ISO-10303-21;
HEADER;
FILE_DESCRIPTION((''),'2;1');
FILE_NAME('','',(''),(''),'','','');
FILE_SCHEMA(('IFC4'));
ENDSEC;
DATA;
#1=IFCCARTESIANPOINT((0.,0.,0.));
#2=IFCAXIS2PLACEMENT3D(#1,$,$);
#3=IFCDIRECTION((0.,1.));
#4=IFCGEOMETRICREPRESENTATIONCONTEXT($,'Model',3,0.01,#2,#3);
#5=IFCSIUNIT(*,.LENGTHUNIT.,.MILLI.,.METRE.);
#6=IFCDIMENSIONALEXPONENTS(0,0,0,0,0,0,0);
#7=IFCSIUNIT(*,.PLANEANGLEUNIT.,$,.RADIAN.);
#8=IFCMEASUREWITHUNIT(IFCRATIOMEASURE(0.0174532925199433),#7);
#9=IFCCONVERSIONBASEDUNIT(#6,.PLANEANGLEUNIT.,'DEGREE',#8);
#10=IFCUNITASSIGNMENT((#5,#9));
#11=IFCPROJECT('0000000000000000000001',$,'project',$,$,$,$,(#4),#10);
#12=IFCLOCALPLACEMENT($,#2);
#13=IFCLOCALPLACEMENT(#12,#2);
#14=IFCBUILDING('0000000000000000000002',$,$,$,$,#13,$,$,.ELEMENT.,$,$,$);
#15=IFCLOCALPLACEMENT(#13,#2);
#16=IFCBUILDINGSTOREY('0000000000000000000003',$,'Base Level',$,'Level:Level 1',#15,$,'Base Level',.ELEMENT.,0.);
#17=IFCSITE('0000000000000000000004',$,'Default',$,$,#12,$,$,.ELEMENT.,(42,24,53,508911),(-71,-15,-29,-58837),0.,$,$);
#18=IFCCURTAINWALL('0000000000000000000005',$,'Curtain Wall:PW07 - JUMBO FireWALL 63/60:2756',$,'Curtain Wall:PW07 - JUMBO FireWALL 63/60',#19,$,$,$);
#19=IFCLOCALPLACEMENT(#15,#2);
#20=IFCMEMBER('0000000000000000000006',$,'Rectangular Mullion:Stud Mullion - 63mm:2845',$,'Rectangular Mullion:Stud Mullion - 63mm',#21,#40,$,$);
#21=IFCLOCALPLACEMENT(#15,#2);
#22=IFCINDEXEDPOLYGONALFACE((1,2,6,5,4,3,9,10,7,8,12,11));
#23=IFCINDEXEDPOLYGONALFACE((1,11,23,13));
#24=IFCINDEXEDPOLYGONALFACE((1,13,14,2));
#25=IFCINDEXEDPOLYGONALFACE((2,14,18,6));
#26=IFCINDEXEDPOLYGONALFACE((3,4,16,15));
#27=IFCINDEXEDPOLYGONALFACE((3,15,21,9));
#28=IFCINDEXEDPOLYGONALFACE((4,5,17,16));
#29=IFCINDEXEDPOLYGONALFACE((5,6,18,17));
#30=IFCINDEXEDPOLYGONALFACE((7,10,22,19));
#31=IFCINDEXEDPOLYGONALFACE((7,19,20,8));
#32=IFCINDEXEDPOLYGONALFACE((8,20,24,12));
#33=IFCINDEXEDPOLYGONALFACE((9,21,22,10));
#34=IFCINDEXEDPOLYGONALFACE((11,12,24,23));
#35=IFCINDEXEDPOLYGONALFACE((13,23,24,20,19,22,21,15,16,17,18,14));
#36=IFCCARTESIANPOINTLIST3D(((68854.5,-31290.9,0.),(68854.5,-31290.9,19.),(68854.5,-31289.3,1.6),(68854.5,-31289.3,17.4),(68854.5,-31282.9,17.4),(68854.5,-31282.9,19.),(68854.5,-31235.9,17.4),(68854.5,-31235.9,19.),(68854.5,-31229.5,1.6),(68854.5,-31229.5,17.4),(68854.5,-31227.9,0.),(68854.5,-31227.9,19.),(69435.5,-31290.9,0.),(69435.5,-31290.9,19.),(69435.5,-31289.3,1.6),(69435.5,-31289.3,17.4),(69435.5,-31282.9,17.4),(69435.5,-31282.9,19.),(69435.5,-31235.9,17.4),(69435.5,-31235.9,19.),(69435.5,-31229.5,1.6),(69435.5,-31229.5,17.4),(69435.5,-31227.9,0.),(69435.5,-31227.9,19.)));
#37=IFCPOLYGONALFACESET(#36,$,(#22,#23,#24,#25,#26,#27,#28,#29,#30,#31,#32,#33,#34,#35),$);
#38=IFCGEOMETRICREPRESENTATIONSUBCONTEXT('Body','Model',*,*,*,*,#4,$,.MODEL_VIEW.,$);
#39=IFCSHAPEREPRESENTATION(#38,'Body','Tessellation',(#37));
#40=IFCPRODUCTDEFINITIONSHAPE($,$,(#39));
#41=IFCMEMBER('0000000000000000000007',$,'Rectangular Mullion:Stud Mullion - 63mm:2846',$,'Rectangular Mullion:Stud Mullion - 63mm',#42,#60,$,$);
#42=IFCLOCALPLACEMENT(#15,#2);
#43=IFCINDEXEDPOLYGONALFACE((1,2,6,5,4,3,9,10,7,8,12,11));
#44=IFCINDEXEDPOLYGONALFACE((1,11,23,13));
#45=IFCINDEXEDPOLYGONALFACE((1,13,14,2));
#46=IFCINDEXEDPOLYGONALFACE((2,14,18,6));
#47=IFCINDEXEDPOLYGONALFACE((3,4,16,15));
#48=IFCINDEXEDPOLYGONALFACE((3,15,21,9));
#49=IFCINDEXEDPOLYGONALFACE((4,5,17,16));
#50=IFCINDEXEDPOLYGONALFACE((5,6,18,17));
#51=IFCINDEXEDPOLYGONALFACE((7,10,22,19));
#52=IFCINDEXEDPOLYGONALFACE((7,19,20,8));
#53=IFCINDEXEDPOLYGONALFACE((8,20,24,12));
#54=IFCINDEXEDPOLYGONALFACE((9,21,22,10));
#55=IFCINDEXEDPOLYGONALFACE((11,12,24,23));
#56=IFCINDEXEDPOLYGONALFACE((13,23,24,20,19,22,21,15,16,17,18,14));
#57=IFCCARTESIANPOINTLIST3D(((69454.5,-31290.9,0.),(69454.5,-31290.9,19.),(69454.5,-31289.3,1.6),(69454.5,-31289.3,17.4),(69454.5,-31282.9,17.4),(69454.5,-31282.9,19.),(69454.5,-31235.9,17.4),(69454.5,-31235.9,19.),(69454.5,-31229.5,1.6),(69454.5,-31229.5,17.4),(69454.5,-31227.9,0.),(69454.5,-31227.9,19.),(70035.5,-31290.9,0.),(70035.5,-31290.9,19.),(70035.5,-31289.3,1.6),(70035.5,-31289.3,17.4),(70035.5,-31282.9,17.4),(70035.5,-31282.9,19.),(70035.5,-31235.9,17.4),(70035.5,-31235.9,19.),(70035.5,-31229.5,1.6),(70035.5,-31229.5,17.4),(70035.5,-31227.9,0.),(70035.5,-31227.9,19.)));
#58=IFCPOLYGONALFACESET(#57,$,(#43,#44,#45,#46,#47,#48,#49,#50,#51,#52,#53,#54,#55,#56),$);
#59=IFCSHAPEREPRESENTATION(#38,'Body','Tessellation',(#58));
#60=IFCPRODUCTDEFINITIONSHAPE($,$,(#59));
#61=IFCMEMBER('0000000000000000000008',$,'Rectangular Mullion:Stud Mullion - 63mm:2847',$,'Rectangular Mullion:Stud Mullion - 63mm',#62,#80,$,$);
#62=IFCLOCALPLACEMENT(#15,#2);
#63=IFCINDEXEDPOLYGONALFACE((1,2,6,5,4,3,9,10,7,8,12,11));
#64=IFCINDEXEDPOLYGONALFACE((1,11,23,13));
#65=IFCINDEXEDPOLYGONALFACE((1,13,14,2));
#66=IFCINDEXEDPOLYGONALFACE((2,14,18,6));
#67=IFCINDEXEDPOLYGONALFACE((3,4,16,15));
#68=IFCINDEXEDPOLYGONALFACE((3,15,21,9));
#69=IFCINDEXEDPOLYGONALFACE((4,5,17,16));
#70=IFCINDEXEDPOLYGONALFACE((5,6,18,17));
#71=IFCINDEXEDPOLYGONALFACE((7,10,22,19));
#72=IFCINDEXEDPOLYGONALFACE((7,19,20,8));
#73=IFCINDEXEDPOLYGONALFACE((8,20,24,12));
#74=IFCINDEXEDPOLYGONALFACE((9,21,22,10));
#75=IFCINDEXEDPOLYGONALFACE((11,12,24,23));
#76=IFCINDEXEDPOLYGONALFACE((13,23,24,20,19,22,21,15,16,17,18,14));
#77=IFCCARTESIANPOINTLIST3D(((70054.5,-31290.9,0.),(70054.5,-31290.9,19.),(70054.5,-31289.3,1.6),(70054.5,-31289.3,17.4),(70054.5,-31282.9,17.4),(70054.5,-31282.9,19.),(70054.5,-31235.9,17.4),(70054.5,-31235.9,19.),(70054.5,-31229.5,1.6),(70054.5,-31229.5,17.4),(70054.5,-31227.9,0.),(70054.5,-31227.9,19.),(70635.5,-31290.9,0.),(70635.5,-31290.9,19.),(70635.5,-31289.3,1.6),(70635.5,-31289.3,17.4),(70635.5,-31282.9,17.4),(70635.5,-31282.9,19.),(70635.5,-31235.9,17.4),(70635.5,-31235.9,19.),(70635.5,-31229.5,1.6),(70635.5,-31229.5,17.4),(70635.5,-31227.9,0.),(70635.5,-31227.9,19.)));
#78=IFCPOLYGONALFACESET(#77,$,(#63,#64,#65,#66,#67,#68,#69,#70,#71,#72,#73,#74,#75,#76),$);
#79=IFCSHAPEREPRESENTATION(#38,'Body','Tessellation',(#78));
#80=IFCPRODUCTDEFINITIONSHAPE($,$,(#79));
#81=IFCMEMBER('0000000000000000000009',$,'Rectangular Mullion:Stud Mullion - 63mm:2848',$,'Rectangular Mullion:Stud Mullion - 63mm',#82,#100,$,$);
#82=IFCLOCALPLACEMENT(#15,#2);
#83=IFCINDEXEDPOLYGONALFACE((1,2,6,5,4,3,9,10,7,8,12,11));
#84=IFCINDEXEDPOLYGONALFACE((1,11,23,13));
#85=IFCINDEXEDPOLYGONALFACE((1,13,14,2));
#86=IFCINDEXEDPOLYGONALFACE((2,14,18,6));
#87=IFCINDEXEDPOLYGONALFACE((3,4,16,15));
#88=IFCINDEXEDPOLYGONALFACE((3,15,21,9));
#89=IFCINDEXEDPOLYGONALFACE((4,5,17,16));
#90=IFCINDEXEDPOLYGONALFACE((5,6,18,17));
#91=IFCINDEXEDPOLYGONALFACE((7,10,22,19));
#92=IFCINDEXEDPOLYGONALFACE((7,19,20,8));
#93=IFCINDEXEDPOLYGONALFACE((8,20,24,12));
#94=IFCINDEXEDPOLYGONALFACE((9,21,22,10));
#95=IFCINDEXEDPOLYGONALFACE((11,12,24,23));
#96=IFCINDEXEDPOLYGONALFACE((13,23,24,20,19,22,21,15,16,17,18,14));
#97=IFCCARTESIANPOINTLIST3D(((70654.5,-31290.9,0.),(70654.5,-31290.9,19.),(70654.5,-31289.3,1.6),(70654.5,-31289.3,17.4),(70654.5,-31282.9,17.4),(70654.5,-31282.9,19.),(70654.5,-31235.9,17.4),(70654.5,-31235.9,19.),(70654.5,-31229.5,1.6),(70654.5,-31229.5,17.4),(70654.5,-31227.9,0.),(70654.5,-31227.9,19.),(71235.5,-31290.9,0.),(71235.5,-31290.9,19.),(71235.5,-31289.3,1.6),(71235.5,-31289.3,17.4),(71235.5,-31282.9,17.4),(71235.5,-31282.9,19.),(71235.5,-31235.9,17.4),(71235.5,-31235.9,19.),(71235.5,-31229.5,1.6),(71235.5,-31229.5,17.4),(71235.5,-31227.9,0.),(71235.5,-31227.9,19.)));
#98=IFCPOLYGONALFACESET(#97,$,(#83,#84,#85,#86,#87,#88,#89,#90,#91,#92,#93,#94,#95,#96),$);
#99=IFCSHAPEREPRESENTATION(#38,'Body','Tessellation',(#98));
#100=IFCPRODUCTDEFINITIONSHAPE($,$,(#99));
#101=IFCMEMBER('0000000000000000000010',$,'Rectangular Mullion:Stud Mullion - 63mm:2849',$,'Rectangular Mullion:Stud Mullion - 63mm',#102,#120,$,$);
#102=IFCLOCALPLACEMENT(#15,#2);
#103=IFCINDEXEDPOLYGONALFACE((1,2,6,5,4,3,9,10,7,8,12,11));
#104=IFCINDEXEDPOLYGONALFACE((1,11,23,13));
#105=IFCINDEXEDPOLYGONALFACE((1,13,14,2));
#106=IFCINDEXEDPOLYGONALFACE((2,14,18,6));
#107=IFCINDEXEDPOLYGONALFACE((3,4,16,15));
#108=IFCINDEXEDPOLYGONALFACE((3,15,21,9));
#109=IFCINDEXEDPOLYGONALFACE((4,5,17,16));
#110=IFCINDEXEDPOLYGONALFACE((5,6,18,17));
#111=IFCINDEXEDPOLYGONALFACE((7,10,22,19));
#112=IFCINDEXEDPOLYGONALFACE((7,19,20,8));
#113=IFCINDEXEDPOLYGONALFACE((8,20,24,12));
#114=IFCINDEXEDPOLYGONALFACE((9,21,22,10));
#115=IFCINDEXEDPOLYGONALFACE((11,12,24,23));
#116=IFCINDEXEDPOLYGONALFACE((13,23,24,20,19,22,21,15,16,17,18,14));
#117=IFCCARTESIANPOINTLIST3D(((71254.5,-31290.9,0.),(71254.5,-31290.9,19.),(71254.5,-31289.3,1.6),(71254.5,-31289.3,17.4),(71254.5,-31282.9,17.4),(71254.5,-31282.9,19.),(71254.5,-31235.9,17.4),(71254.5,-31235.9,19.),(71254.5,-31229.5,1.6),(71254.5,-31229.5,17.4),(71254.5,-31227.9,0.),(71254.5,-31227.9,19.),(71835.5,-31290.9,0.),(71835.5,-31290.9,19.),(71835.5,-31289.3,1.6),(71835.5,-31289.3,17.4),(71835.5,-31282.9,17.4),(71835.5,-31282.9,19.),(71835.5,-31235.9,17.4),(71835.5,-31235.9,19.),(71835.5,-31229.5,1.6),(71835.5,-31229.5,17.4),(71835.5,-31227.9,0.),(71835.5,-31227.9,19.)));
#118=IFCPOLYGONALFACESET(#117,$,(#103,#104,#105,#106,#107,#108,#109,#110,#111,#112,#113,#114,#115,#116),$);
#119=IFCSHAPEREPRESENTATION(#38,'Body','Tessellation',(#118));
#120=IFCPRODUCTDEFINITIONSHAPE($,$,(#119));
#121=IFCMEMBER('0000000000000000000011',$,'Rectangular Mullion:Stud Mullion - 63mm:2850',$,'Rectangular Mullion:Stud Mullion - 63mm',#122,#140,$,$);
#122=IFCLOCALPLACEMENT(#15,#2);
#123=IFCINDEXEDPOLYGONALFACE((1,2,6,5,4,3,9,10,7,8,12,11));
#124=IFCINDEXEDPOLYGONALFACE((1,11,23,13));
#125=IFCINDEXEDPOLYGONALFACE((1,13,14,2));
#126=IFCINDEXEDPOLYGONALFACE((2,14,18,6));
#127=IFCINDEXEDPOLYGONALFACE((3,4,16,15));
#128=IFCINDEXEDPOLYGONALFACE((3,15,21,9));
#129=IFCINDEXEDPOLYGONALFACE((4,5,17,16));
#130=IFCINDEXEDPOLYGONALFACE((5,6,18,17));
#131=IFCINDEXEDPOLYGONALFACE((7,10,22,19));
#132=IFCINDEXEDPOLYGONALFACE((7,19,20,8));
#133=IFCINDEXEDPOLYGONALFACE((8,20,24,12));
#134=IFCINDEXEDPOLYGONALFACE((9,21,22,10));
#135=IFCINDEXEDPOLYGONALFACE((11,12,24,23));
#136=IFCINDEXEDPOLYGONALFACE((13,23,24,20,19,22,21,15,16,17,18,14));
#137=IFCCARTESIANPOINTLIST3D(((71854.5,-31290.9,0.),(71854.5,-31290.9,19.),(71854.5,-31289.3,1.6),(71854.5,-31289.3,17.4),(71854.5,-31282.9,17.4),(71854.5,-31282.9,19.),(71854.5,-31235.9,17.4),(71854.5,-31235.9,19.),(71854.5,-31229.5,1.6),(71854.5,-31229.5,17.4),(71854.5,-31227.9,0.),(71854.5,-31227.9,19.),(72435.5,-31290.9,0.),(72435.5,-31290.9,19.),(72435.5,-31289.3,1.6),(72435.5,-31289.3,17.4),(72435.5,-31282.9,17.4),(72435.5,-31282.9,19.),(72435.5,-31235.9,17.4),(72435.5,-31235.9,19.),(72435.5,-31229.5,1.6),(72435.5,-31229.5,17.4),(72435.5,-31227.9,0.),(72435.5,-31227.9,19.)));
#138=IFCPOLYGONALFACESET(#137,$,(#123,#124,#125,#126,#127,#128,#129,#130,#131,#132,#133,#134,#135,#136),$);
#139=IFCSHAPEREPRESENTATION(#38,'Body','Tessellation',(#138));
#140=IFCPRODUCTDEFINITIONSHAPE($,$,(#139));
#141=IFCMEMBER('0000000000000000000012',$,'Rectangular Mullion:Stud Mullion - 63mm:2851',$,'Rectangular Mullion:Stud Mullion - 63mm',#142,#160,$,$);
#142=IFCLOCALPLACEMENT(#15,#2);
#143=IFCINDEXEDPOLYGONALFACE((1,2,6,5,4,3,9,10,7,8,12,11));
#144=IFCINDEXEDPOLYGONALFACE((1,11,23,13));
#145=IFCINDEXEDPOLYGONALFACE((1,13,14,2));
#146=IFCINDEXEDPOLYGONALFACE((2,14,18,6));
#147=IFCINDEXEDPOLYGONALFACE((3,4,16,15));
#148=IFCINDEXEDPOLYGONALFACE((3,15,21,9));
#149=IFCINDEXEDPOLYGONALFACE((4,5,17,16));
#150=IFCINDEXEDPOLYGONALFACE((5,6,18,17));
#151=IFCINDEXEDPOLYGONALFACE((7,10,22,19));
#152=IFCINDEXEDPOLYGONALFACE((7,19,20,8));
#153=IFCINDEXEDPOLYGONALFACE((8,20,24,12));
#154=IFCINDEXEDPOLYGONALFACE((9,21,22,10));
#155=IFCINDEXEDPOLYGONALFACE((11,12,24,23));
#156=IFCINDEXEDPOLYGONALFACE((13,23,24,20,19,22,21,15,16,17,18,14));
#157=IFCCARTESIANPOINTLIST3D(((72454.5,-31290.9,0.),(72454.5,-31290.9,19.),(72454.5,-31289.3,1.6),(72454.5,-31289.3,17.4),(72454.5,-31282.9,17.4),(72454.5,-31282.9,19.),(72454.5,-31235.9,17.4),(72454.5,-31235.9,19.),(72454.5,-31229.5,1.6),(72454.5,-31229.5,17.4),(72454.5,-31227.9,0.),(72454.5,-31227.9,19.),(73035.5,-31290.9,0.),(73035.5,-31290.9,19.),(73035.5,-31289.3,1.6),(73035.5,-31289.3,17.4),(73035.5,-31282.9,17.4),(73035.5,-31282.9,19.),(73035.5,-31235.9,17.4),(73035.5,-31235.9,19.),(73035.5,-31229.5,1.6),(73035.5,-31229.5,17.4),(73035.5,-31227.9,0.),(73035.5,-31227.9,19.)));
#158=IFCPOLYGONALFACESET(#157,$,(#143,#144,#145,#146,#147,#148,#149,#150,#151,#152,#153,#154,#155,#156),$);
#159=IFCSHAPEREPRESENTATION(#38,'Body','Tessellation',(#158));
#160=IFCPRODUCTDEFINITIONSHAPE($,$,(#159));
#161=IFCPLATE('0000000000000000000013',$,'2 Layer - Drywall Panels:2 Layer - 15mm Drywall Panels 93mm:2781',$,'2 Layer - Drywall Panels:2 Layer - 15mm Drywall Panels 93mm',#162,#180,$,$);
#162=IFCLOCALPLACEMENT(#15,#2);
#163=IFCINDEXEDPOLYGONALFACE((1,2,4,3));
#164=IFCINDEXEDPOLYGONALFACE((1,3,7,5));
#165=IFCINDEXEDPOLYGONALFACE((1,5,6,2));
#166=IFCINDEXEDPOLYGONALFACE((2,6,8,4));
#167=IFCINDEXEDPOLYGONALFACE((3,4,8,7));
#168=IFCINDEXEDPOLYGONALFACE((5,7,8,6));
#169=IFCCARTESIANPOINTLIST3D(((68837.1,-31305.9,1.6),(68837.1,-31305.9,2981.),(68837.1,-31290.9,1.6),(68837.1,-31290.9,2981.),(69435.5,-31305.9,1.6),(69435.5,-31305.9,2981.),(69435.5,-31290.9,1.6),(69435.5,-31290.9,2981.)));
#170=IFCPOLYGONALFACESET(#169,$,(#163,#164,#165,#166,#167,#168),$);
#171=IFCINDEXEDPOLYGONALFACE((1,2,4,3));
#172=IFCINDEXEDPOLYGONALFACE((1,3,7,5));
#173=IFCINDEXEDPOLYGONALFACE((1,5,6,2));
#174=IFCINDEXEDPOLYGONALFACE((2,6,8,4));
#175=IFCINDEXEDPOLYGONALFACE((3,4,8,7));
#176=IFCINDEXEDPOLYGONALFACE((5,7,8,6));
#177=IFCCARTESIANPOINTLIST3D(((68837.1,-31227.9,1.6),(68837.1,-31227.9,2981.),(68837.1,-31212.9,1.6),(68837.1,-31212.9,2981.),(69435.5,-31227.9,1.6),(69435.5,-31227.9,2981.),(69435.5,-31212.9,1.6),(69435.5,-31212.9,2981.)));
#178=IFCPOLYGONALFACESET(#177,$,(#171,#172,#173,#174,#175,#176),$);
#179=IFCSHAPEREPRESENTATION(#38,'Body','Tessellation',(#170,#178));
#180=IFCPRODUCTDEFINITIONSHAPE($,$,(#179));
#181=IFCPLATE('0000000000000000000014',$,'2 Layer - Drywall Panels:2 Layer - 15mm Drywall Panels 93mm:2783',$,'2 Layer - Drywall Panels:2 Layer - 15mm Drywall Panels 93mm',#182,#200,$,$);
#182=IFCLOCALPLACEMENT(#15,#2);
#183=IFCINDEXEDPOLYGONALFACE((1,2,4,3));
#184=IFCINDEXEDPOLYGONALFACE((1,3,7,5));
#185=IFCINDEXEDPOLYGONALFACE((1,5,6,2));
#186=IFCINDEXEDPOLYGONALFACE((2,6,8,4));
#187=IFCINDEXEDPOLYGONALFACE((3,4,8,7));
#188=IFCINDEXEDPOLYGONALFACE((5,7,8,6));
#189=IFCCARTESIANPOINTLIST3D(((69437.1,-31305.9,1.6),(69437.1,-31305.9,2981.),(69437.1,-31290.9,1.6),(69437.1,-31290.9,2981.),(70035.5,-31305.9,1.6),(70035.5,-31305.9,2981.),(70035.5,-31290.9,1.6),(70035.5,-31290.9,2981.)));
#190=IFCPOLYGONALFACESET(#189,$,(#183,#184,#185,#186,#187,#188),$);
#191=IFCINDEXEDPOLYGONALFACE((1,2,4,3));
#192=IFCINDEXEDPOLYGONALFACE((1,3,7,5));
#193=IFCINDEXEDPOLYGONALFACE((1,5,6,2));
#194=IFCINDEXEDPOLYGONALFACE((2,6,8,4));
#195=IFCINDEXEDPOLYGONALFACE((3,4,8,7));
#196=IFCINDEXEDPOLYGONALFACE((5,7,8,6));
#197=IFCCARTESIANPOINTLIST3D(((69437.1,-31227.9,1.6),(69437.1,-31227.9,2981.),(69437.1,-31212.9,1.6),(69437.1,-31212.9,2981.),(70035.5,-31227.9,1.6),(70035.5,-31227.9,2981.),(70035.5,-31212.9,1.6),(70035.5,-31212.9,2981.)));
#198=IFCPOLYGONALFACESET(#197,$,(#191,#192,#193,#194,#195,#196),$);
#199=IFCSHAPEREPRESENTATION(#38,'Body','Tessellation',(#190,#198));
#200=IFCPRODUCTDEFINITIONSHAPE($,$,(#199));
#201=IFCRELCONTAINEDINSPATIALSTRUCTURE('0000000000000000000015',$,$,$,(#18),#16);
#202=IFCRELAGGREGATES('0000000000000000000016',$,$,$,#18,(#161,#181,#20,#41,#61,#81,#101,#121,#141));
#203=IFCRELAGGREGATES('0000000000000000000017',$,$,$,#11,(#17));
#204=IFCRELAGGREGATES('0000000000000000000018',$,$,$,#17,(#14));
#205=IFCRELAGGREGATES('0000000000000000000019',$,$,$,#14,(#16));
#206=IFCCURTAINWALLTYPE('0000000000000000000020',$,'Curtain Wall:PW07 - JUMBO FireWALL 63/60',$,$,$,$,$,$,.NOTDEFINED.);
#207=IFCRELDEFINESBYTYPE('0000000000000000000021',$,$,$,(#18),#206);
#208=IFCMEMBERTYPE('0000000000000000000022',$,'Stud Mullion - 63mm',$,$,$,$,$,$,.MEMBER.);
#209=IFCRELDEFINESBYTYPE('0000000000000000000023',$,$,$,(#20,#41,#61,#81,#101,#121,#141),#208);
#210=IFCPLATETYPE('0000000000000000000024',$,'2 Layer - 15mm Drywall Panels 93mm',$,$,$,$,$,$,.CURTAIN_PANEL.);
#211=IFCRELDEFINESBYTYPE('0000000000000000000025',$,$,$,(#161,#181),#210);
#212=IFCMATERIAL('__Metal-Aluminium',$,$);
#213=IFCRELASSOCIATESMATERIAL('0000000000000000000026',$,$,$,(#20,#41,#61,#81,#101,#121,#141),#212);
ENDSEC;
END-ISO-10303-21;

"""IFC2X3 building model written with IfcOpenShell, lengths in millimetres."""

from ifc_helpers import new_model, entity, si_unit, converted_unit, direction, frame, frame_2d, origin, place, context, subcontext, project, spatial, polyline, rectangle, outline, extrude, source, transform, mapped, material, type_object, type_shapes, element, aggregate, save


model = new_model("IFC2X3")

# Units and contexts
model_context = context("Model", 3, precision=0.01, world=origin(), true_north=direction((0.0, 1.0)))
body_context = subcontext(model_context, "Body", "Model", "MODEL_VIEW")
ifc_project = project(units=[si_unit("LENGTHUNIT", "METRE", prefix="MILLI"), converted_unit("PLANEANGLEUNIT", "DEGREE", entity("IfcRatioMeasure", 0.0174532925199433), si_unit("PLANEANGLEUNIT", "RADIAN"), dimensions=[0, 0, 0, 0, 0, 0, 0])], contexts=[model_context])

# Site, building, storey
site_placement = place(None, origin())
site = spatial("IfcSite", under=ifc_project, at=site_placement, Name="Default", CompositionType="ELEMENT", RefLatitude=(42, 24, 53, 508911), RefLongitude=(-71, -15, -29, -58837), RefElevation=0.0)
building_placement = place(site_placement, origin())
building = spatial("IfcBuilding", under=site, at=building_placement, CompositionType="ELEMENT")
storey_placement = place(building_placement, origin())
storey = spatial("IfcBuildingStorey", under=building, at=storey_placement, Name="Base Level", ObjectType="Level:Level 1", LongName="Base Level", CompositionType="ELEMENT", Elevation=0.0)

# Curtain wall, members, plates
curtain_wall_type = type_object("IfcCurtainWallType", Name="Curtain Wall:PW07 - JUMBO FireWALL 63/60", PredefinedType="NOTDEFINED")
curtain_wall_placement = place(building_placement, origin())
curtain_wall = element("IfcCurtainWall", 1, at=curtain_wall_placement, inside=storey, type_object=curtain_wall_type, Name="Curtain Wall:PW07 - JUMBO FireWALL 63/60:2756", ObjectType="Curtain Wall:PW07 - JUMBO FireWALL 63/60")
ifc_material = material(Name="__Metal-Aluminium")
member_type_1 = type_object("IfcMemberType", Name="Stud Mullion - 63mm", PredefinedType="MEMBER")
shared_shape_1 = source(origin(), body_context, "Body", "SweptSolid", [
    extrude(outline(polyline([(23.5, -6.6), (31.5, -6.6), (31.5, 12.4), (-31.5, 12.4), (-31.5, -6.6), (-23.5, -6.6), (-23.5, -5.0), (-29.9, -5.0), (-29.9, 10.8), (29.9, 10.8), (29.9, -5.0), (23.5, -5.0), (23.5, -6.6)])), frame((-12.4, 0.0, -581.0), z_axis=(0.0, 0.0, 1.0), x_axis=(0.0, -1.0, 0.0)), (0.0, 0.0, 1.0), 581.0),
])
type_shapes(member_type_1, [shared_shape_1])
member_1_placement = place(building_placement, frame((68854.5, -31259.4, 0.0), z_axis=(-1.0, 0.0, 0.0), x_axis=(0.0, 0.0, -1.0)))
member_1 = element("IfcMember", 2, at=member_1_placement, type_object=member_type_1, material=ifc_material, Name="Rectangular Mullion:Stud Mullion - 63mm:2845", ObjectType="Rectangular Mullion:Stud Mullion - 63mm", context=body_context, shape_type="MappedRepresentation", body=[
    mapped(shared_shape_1, transform((0.0, 0.0, 0.0), scale=1.0)),
])
member_2_placement = place(building_placement, frame((69454.5, -31259.4, 0.0), z_axis=(-1.0, 0.0, 0.0), x_axis=(0.0, 0.0, -1.0)))
member_2 = element("IfcMember", 3, at=member_2_placement, type_object=member_type_1, material=ifc_material, Name="Rectangular Mullion:Stud Mullion - 63mm:2846", ObjectType="Rectangular Mullion:Stud Mullion - 63mm", context=body_context, shape_type="MappedRepresentation", body=[
    mapped(shared_shape_1, transform((0.0, 0.0, 0.0), scale=1.0)),
])
member_3_placement = place(building_placement, frame((70054.5, -31259.4, 0.0), z_axis=(-1.0, 0.0, 0.0), x_axis=(0.0, 0.0, -1.0)))
member_3 = element("IfcMember", 4, at=member_3_placement, type_object=member_type_1, material=ifc_material, Name="Rectangular Mullion:Stud Mullion - 63mm:2847", ObjectType="Rectangular Mullion:Stud Mullion - 63mm", context=body_context, shape_type="MappedRepresentation", body=[
    mapped(shared_shape_1, transform((0.0, 0.0, 0.0), scale=1.0)),
])
member_4_placement = place(building_placement, frame((70654.5, -31259.4, 0.0), z_axis=(-1.0, 0.0, 0.0), x_axis=(0.0, 0.0, -1.0)))
member_4 = element("IfcMember", 5, at=member_4_placement, type_object=member_type_1, material=ifc_material, Name="Rectangular Mullion:Stud Mullion - 63mm:2848", ObjectType="Rectangular Mullion:Stud Mullion - 63mm", context=body_context, shape_type="MappedRepresentation", body=[
    mapped(shared_shape_1, transform((0.0, 0.0, 0.0), scale=1.0)),
])
member_5_placement = place(building_placement, frame((71254.5, -31259.4, 0.0), z_axis=(-1.0, 0.0, 0.0), x_axis=(0.0, 0.0, -1.0)))
member_5 = element("IfcMember", 6, at=member_5_placement, type_object=member_type_1, material=ifc_material, Name="Rectangular Mullion:Stud Mullion - 63mm:2849", ObjectType="Rectangular Mullion:Stud Mullion - 63mm", context=body_context, shape_type="MappedRepresentation", body=[
    mapped(shared_shape_1, transform((0.0, 0.0, 0.0), scale=1.0)),
])
member_6_placement = place(building_placement, frame((71854.5, -31259.4, 0.0), z_axis=(-1.0, 0.0, 0.0), x_axis=(0.0, 0.0, -1.0)))
member_6 = element("IfcMember", 7, at=member_6_placement, type_object=member_type_1, material=ifc_material, Name="Rectangular Mullion:Stud Mullion - 63mm:2850", ObjectType="Rectangular Mullion:Stud Mullion - 63mm", context=body_context, shape_type="MappedRepresentation", body=[
    mapped(shared_shape_1, transform((0.0, 0.0, 0.0), scale=1.0)),
])
member_7_placement = place(building_placement, frame((72454.5, -31259.4, 0.0), z_axis=(-1.0, 0.0, 0.0), x_axis=(0.0, 0.0, -1.0)))
member_7 = element("IfcMember", 8, at=member_7_placement, type_object=member_type_1, material=ifc_material, Name="Rectangular Mullion:Stud Mullion - 63mm:2851", ObjectType="Rectangular Mullion:Stud Mullion - 63mm", context=body_context, shape_type="MappedRepresentation", body=[
    mapped(shared_shape_1, transform((0.0, 0.0, 0.0), scale=1.0)),
])
plate_type = type_object("IfcPlateType", Name="2 Layer - 15mm Drywall Panels 93mm", PredefinedType="CURTAIN_PANEL")
shared_shape_2 = source(origin(), body_context, "Body", "SweptSolid", [
    extrude(rectangle(XDim=598.4, YDim=15.0, at=frame_2d((0.0, 0.0), x_axis=(1.0, 0.0))), frame((0.0, -39.0, 0.0), z_axis=(0.0, 0.0, 1.0), x_axis=(-1.0, 0.0, 0.0)), (0.0, 0.0, 1.0), 2979.4),
    extrude(rectangle(XDim=15.0, YDim=598.4, at=frame_2d((0.0, 0.0), x_axis=(1.0, 0.0))), frame((0.0, 39.0, 0.0), z_axis=(0.0, 0.0, 1.0), x_axis=(0.0, 1.0, 0.0)), (0.0, 0.0, 1.0), 2979.4),
])
type_shapes(plate_type, [shared_shape_2])
plate_1_placement = place(curtain_wall_placement, frame((69136.3, -31259.4, 1.6)))
plate_1 = element("IfcPlate", 9, at=plate_1_placement, type_object=plate_type, Name="2 Layer - Drywall Panels:2 Layer - 15mm Drywall Panels 93mm:2781", ObjectType="2 Layer - Drywall Panels:2 Layer - 15mm Drywall Panels 93mm", context=body_context, shape_type="MappedRepresentation", body=[
    mapped(shared_shape_2, transform((0.0, 0.0, 0.0), scale=1.0)),
])
plate_2_placement = place(curtain_wall_placement, frame((69736.3, -31259.4, 1.6)))
plate_2 = element("IfcPlate", 10, at=plate_2_placement, type_object=plate_type, Name="2 Layer - Drywall Panels:2 Layer - 15mm Drywall Panels 93mm:2783", ObjectType="2 Layer - Drywall Panels:2 Layer - 15mm Drywall Panels 93mm", context=body_context, shape_type="MappedRepresentation", body=[
    mapped(shared_shape_2, transform((0.0, 0.0, 0.0), scale=1.0)),
])
aggregate(curtain_wall, [plate_1, plate_2, member_1, member_2, member_3, member_4, member_5, member_6, member_7])

save(model, "model.ifc")
